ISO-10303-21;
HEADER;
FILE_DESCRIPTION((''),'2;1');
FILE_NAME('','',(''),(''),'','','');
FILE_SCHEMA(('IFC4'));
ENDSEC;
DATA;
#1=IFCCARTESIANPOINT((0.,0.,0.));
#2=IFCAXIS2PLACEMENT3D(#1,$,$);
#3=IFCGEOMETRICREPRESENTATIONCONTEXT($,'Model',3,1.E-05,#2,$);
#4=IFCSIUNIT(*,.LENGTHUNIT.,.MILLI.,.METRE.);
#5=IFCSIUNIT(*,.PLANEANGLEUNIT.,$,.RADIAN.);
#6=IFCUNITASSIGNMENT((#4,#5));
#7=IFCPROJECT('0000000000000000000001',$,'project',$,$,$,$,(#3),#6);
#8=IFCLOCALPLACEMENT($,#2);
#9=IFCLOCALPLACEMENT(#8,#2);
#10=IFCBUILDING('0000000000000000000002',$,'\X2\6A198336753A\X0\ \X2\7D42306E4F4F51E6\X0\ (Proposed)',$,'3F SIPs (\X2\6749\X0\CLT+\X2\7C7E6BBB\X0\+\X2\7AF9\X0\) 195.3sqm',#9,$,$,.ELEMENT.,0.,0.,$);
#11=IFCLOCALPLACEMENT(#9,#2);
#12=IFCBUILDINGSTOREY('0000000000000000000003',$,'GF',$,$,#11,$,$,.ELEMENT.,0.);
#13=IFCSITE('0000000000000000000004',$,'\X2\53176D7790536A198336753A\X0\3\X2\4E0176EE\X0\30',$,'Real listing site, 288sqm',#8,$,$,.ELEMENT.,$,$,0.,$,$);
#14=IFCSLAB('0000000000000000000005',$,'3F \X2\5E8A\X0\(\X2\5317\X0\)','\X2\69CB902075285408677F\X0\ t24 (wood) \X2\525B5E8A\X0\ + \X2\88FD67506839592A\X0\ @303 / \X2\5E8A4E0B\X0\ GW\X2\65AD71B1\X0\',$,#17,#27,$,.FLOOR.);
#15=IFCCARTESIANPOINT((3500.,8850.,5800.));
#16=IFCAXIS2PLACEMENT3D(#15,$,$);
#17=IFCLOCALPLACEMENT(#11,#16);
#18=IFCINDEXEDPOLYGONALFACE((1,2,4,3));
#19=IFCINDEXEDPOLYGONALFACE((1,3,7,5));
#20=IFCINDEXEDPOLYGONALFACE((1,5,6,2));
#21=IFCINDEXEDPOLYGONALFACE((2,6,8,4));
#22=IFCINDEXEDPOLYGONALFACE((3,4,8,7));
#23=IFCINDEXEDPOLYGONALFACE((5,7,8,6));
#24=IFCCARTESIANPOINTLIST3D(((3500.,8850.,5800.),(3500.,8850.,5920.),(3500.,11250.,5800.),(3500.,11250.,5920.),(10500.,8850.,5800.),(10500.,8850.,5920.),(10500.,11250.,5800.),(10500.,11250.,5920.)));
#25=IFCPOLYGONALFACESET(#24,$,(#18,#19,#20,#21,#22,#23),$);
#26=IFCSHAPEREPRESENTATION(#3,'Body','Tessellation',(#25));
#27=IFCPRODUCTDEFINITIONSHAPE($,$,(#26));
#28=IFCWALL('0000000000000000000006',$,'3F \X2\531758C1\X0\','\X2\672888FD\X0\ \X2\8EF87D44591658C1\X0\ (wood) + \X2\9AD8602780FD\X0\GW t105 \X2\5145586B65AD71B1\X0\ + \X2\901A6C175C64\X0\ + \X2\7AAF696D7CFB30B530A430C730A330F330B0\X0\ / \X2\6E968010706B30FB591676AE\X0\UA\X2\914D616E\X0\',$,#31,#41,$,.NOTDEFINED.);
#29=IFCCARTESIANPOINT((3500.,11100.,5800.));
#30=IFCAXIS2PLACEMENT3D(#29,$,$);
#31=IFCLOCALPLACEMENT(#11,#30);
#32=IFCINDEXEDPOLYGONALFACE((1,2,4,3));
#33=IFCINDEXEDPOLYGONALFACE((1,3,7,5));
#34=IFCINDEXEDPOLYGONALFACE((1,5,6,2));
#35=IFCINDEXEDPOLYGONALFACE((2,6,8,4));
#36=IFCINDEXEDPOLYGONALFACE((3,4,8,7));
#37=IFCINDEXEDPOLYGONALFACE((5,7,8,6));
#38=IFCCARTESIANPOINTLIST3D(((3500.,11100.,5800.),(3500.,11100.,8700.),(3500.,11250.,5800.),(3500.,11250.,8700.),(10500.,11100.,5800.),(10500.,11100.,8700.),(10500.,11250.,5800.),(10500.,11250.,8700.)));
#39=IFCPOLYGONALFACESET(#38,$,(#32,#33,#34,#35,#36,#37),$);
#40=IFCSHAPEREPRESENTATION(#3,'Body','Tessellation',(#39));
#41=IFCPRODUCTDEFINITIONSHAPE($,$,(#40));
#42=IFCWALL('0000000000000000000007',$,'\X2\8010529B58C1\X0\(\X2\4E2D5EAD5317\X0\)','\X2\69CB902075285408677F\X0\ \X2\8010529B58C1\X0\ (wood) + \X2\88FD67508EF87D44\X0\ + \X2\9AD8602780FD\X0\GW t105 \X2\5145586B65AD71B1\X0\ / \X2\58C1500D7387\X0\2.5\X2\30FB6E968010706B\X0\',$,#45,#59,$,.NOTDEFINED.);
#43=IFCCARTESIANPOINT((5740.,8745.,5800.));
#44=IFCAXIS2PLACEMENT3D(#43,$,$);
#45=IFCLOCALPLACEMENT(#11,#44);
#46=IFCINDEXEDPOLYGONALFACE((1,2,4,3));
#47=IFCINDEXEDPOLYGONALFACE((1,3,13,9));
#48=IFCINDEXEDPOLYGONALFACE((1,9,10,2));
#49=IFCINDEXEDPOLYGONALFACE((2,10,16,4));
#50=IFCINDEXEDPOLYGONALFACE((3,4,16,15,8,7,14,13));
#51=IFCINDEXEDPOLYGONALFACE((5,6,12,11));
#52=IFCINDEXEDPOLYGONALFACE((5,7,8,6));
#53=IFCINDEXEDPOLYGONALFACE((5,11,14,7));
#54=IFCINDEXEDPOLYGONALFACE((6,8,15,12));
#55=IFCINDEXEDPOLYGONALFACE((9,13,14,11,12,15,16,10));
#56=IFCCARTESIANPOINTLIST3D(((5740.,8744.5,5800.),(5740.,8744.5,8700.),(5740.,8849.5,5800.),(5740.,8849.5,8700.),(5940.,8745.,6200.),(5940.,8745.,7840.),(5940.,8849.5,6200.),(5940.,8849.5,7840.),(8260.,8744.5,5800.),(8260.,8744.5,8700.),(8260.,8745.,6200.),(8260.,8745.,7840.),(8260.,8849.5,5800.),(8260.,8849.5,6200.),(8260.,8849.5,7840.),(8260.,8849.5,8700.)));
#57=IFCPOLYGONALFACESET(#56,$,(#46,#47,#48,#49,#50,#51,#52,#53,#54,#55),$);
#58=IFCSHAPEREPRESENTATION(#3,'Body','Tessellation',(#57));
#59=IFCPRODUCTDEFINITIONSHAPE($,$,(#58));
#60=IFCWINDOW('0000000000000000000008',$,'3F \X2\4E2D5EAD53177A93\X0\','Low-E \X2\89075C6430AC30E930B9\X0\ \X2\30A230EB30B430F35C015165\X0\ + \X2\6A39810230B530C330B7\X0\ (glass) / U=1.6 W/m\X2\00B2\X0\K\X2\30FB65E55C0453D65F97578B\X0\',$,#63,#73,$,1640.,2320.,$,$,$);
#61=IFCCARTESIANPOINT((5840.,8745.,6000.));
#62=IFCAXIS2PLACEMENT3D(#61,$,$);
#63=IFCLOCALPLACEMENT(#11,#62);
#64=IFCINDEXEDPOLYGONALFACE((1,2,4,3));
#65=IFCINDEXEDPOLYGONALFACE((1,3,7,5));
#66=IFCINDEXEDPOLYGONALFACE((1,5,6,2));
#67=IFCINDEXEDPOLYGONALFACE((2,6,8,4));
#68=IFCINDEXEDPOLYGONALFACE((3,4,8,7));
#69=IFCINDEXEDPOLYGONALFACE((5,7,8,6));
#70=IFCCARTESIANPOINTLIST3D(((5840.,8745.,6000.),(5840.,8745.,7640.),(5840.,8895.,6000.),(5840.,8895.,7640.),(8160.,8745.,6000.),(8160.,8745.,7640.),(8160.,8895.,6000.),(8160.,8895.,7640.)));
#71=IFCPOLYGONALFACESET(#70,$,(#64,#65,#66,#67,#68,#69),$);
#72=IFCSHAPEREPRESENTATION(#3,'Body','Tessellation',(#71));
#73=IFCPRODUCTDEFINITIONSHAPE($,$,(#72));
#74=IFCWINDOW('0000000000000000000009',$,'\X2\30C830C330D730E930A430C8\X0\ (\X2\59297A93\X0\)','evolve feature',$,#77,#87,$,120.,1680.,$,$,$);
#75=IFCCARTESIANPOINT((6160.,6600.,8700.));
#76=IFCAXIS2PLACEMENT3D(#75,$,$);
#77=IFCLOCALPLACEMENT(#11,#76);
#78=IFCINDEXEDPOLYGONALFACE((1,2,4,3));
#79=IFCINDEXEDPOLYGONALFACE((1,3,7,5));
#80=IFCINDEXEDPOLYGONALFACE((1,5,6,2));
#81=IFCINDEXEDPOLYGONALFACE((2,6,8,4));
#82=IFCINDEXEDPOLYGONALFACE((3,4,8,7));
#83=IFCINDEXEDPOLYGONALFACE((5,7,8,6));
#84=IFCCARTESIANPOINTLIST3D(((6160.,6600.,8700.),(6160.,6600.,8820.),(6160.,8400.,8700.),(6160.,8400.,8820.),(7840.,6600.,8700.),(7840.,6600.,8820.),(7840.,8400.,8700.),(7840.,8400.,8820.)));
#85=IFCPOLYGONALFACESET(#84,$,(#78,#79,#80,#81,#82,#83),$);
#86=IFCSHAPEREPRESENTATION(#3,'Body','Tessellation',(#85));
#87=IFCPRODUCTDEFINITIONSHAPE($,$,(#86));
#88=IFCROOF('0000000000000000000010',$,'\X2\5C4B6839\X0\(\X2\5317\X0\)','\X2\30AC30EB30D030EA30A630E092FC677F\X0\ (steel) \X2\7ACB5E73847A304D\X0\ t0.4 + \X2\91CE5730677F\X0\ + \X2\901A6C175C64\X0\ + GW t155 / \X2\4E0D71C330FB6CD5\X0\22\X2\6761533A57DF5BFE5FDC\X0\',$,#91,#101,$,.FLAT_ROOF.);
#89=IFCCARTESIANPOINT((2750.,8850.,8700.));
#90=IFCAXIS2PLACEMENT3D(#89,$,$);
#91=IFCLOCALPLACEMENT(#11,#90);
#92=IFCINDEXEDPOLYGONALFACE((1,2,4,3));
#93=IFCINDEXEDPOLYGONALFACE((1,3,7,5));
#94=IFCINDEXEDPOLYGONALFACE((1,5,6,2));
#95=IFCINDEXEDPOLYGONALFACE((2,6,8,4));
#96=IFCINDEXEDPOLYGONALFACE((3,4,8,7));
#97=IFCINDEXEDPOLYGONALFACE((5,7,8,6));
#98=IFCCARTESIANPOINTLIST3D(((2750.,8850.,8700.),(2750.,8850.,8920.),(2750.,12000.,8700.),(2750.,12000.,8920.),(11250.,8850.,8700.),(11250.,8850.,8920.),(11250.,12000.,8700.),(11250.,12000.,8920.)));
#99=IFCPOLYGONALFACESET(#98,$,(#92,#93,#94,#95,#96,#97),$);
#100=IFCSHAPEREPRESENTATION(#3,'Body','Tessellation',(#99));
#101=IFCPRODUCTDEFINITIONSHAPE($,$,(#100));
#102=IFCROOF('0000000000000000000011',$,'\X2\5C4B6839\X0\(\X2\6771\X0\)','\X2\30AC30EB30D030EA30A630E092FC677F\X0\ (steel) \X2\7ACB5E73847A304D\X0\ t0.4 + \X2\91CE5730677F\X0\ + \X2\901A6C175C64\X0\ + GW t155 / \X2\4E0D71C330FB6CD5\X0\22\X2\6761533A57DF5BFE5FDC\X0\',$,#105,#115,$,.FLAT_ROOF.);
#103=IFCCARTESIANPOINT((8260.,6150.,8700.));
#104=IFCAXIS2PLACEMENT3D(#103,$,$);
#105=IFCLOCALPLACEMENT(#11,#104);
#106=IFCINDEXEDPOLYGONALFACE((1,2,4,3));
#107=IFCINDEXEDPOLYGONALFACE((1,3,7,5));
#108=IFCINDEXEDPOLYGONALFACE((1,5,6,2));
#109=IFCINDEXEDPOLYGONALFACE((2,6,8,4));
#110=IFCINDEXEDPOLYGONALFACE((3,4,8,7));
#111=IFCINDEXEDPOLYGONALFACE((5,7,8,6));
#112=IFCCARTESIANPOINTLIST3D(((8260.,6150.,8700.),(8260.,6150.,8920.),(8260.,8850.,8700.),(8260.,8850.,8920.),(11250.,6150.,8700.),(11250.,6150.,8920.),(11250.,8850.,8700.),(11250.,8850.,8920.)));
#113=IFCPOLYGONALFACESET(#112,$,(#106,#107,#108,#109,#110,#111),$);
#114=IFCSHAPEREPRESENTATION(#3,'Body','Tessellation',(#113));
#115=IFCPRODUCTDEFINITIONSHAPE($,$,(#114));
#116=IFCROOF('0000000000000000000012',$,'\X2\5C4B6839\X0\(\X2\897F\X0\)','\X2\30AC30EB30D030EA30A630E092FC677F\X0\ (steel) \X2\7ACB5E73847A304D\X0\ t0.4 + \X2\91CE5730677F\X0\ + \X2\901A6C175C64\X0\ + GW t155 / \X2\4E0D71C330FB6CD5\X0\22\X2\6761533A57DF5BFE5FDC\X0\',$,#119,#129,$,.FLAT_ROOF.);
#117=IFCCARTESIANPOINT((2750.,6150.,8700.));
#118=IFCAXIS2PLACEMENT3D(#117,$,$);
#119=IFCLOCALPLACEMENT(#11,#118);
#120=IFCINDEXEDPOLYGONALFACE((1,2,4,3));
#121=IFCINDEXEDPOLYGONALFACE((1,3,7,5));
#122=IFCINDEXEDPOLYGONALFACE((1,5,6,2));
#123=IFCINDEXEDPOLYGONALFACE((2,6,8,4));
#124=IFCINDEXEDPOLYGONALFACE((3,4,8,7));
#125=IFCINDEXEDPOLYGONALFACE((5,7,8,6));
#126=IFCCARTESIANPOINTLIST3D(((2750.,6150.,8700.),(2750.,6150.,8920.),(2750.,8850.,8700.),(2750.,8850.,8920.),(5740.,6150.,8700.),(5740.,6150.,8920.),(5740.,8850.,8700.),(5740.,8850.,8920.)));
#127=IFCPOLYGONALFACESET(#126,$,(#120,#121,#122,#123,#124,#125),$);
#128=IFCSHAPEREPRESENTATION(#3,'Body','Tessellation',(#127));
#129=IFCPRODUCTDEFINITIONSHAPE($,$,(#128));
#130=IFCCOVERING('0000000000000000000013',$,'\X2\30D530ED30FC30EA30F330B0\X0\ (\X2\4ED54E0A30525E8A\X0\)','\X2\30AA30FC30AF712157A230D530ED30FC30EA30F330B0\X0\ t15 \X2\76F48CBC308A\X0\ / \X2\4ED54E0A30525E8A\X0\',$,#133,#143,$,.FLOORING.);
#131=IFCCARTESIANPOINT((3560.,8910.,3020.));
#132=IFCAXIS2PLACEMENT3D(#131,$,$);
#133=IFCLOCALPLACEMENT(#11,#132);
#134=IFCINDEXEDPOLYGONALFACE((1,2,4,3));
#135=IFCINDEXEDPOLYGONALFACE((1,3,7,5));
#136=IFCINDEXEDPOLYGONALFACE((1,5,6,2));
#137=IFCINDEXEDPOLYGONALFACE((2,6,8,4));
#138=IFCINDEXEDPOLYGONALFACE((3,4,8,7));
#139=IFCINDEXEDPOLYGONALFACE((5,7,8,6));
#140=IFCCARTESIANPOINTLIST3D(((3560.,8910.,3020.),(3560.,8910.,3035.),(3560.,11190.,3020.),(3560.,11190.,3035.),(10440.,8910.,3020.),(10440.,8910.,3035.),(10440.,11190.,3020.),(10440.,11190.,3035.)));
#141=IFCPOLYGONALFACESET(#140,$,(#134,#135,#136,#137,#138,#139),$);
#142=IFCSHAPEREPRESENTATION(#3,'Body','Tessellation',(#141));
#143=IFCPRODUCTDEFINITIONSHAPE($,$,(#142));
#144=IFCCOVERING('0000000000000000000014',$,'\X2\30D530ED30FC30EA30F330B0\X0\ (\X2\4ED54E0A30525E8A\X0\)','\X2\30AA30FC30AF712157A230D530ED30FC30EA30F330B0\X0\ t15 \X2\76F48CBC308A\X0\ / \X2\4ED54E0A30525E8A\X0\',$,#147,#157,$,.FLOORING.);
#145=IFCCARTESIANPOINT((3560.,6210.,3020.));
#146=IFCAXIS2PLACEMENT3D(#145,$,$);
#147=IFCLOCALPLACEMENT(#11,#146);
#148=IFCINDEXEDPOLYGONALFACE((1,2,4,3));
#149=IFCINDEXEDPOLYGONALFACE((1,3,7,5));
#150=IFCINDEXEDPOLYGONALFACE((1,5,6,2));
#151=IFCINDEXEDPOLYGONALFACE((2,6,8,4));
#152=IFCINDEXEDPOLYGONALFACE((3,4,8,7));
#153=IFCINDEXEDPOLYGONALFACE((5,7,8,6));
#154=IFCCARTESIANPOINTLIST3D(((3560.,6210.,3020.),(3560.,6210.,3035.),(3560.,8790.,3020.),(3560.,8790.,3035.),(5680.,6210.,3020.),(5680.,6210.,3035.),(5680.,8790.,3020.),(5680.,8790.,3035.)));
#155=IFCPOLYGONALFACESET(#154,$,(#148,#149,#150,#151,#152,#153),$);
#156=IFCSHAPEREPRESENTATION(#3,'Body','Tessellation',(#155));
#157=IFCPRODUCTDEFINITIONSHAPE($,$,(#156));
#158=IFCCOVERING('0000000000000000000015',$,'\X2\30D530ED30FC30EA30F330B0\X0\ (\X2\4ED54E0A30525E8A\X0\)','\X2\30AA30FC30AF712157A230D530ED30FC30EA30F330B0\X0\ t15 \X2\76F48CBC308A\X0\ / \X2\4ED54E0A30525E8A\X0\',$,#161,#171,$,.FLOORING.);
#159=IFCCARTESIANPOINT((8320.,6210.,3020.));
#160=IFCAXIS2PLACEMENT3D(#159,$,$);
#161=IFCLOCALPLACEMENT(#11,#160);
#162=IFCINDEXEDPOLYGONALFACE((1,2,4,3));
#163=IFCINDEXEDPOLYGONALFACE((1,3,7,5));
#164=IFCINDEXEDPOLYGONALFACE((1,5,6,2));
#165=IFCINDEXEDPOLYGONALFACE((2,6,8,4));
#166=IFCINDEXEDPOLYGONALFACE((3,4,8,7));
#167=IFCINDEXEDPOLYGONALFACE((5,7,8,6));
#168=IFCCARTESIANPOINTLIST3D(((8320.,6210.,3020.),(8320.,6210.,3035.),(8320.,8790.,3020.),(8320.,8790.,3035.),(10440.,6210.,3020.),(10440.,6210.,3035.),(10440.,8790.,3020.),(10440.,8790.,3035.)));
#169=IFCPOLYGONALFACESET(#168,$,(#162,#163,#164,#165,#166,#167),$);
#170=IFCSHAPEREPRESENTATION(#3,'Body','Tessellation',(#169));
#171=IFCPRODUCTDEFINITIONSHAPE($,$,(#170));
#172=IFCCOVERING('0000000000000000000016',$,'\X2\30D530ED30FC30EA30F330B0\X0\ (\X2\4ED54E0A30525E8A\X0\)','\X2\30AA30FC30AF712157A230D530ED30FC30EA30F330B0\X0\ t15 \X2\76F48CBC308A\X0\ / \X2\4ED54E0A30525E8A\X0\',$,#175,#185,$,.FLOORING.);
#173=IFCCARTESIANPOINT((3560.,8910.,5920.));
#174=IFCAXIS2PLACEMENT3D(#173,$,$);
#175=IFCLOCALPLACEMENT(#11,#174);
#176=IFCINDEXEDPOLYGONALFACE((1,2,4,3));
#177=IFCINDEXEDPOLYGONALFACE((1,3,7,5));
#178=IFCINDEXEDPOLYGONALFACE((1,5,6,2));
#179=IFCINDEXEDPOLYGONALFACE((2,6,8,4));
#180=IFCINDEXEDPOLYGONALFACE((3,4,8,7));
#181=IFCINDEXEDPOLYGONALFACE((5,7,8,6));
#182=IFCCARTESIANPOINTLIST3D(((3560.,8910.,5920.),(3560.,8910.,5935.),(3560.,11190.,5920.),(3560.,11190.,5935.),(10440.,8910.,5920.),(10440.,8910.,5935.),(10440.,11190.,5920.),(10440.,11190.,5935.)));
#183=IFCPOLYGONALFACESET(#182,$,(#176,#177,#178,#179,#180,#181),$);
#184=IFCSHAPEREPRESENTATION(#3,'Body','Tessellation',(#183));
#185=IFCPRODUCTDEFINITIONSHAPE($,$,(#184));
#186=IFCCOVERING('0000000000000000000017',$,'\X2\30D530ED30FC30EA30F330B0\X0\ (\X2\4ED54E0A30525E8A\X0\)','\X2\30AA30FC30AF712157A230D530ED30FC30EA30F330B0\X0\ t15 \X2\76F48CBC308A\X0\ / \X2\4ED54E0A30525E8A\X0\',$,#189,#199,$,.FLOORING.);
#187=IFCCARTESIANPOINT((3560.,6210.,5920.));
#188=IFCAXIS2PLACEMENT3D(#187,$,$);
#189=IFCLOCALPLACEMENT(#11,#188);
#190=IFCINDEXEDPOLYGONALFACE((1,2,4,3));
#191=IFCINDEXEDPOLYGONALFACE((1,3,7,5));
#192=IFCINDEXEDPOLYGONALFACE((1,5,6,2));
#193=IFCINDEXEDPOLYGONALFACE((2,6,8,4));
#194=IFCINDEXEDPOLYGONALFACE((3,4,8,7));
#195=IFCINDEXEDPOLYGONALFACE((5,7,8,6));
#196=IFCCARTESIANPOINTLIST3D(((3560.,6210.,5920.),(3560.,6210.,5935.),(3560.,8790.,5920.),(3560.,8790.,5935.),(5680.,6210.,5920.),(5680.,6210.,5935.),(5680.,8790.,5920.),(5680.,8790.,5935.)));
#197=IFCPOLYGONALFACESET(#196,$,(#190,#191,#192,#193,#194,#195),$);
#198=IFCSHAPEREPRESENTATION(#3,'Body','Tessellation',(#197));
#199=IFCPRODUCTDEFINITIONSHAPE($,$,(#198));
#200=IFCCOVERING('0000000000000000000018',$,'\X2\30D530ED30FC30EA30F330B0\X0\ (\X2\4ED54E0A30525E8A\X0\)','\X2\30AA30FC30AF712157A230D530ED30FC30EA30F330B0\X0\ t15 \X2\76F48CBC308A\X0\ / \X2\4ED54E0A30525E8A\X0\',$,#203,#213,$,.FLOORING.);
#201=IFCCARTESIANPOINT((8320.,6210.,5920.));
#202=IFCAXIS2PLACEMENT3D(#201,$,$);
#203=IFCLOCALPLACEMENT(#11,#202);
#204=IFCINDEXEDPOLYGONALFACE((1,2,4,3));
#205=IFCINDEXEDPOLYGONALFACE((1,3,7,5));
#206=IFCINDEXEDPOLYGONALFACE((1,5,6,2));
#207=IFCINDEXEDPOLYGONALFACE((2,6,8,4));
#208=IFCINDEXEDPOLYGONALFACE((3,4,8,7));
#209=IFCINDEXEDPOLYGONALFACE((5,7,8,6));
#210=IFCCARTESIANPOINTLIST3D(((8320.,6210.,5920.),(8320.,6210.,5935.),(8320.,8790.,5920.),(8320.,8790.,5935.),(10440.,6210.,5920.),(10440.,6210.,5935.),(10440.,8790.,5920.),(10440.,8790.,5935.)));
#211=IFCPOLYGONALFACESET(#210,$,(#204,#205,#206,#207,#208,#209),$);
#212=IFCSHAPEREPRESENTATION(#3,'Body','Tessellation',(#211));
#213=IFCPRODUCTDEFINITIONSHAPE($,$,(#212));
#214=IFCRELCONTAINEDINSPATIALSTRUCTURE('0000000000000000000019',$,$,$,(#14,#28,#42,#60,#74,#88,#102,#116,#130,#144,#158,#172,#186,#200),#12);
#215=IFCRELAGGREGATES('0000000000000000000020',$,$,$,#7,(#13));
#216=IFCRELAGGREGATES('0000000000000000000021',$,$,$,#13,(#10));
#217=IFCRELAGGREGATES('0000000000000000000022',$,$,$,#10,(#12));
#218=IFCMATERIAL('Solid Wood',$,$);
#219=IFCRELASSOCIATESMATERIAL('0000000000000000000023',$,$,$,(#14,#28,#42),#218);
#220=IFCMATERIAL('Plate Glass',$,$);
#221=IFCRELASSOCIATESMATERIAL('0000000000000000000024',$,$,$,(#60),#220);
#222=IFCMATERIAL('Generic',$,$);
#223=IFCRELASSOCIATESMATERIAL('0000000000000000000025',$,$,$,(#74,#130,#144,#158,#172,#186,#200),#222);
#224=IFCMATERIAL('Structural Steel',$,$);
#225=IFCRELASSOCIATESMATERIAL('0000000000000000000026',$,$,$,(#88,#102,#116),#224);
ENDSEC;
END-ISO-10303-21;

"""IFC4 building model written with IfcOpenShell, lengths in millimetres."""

from ifc_helpers import new_model, si_unit, frame, frame_2d, origin, place, context, project, spatial, rectangle, extrude, material, element, fill, save


model = new_model("IFC4")

# Units and contexts
model_context = context("Model", 3, precision=1e-05, world=origin())
ifc_project = project(units=[si_unit("LENGTHUNIT", "METRE", prefix="MILLI"), si_unit("PLANEANGLEUNIT", "RADIAN")], contexts=[model_context])

# Site, building, storey
site_placement = place(None, origin())
site = spatial("IfcSite", under=ifc_project, at=site_placement, Name="北海道標茶町3丁目30", ObjectType="Real listing site, 288sqm", CompositionType="ELEMENT", RefElevation=0.0)
building_placement = place(site_placement, origin())
building = spatial("IfcBuilding", under=site, at=building_placement, Name="標茶町 終の住処 (Proposed)", ObjectType="3F SIPs (杉CLT+籾殻+竹) 195.3sqm", CompositionType="ELEMENT", ElevationOfRefHeight=0.0, ElevationOfTerrain=0.0)
storey_placement = place(building_placement, origin())
storey = spatial("IfcBuildingStorey", under=building, at=storey_placement, Name="GF", CompositionType="ELEMENT", Elevation=0.0)

# Slab
ifc_material_1 = material(Name="Solid Wood")
slab_placement = place(storey_placement, frame((3500.0, 8850.0, 5800.0)))
element("IfcSlab", 1, at=slab_placement, inside=storey, material=ifc_material_1, Name="3F 床(北)", Description="構造用合板 t24 (wood) 剛床 + 製材根太 @303 / 床下 GW断熱", PredefinedType="FLOOR", context=model_context, shape_type="SweptSolid", body=[
    extrude(rectangle(XDim=7000.0, YDim=2400.0, at=frame_2d((3500.0, 1200.0))), frame((3500.0, 8850.0, 5800.0)), (0.0, 0.0, 1.0), 120.0),
])

# Wall
wall_1_placement = place(storey_placement, frame((3500.0, 11100.0, 5800.0)))
element("IfcWall", 2, at=wall_1_placement, inside=storey, material=ifc_material_1, Name="3F 北壁", Description="木製 軸組外壁 (wood) + 高性能GW t105 充填断熱 + 通気層 + 窯業系サイディング / 準耐火・外皮UA配慮", PredefinedType="NOTDEFINED", context=model_context, shape_type="SweptSolid", body=[
    extrude(rectangle(XDim=7000.0, YDim=150.0, at=frame_2d((3500.0, 75.0))), frame((3500.0, 11100.0, 5800.0)), (0.0, 0.0, 1.0), 2900.0),
])

# Wall, opening, window
wall_2_placement = place(storey_placement, frame((5740.0, 8745.0, 5800.0)))
wall_2 = element("IfcWall", 3, at=wall_2_placement, inside=storey, material=ifc_material_1, Name="耐力壁(中庭北)", Description="構造用合板 耐力壁 (wood) + 製材軸組 + 高性能GW t105 充填断熱 / 壁倍率2.5・準耐火", PredefinedType="NOTDEFINED", context=model_context, shape_type="SweptSolid", body=[
    extrude(rectangle(XDim=2520.0, YDim=105.0, at=frame_2d((1260.0, 52.0))), frame((5740.0, 8745.0, 5800.0)), (0.0, 0.0, 1.0), 2900.0),
])
opening_placement = place(storey_placement, frame((5840.0, 8745.0, 6000.0)))
opening = element("IfcOpeningElement", 4, at=opening_placement, cuts=wall_2, PredefinedType="NOTDEFINED", context=model_context, shape_type="SweptSolid", body=[
    extrude(rectangle(XDim=2320.0, YDim=150.0, at=frame_2d((1160.0, 75.0))), frame((5840.0, 8745.0, 6000.0)), (0.0, 0.0, 1.0), 1640.0),
])
ifc_material_2 = material(Name="Plate Glass")
window_1_placement = place(storey_placement, frame((5840.0, 8745.0, 6000.0)))
window_1 = element("IfcWindow", 5, at=window_1_placement, inside=storey, material=ifc_material_2, Name="3F 中庭北窓", Description="Low-E 複層ガラス アルゴン封入 + 樹脂サッシ (glass) / U=1.6 W/m²K・日射取得型", OverallHeight=1640.0, OverallWidth=2320.0, context=model_context, shape_type="SweptSolid", body=[
    extrude(rectangle(XDim=2320.0, YDim=150.0, at=frame_2d((1160.0, 75.0))), frame((5840.0, 8745.0, 6000.0)), (0.0, 0.0, 1.0), 1640.0),
])
fill(opening, window_1)

# Window
ifc_material_3 = material(Name="Generic")
window_2_placement = place(storey_placement, frame((6160.0, 6600.0, 8700.0)))
element("IfcWindow", 6, at=window_2_placement, inside=storey, material=ifc_material_3, Name="トップライト (天窓)", Description="evolve feature", OverallHeight=120.0, OverallWidth=1680.0, context=model_context, shape_type="SweptSolid", body=[
    extrude(rectangle(XDim=1680.0, YDim=1800.0, at=frame_2d((840.0, 900.0))), frame((6160.0, 6600.0, 8700.0)), (0.0, 0.0, 1.0), 120.0),
])

# Roofs
ifc_material_4 = material(Name="Structural Steel")
roof_1_placement = place(storey_placement, frame((2750.0, 8850.0, 8700.0)))
element("IfcRoof", 7, at=roof_1_placement, inside=storey, material=ifc_material_4, Name="屋根(北)", Description="ガルバリウム鋼板 (steel) 立平葺き t0.4 + 野地板 + 通気層 + GW t155 / 不燃・法22条区域対応", PredefinedType="FLAT_ROOF", context=model_context, shape_type="SweptSolid", body=[
    extrude(rectangle(XDim=8500.0, YDim=3150.0, at=frame_2d((4250.0, 1575.0))), frame((2750.0, 8850.0, 8700.0)), (0.0, 0.0, 1.0), 220.0),
])
roof_2_placement = place(storey_placement, frame((8260.0, 6150.0, 8700.0)))
element("IfcRoof", 8, at=roof_2_placement, inside=storey, material=ifc_material_4, Name="屋根(東)", Description="ガルバリウム鋼板 (steel) 立平葺き t0.4 + 野地板 + 通気層 + GW t155 / 不燃・法22条区域対応", PredefinedType="FLAT_ROOF", context=model_context, shape_type="SweptSolid", body=[
    extrude(rectangle(XDim=2990.0, YDim=2700.0, at=frame_2d((1495.0, 1350.0))), frame((8260.0, 6150.0, 8700.0)), (0.0, 0.0, 1.0), 220.0),
])
roof_3_placement = place(storey_placement, frame((2750.0, 6150.0, 8700.0)))
element("IfcRoof", 9, at=roof_3_placement, inside=storey, material=ifc_material_4, Name="屋根(西)", Description="ガルバリウム鋼板 (steel) 立平葺き t0.4 + 野地板 + 通気層 + GW t155 / 不燃・法22条区域対応", PredefinedType="FLAT_ROOF", context=model_context, shape_type="SweptSolid", body=[
    extrude(rectangle(XDim=2990.0, YDim=2700.0, at=frame_2d((1495.0, 1350.0))), frame((2750.0, 6150.0, 8700.0)), (0.0, 0.0, 1.0), 220.0),
])

# Coverings
covering_1_placement = place(storey_placement, frame((3560.0, 8910.0, 3020.0)))
element("IfcCovering", 10, at=covering_1_placement, inside=storey, material=ifc_material_3, Name="フローリング (仕上げ床)", Description="オーク無垢フローリング t15 直貼り / 仕上げ床", PredefinedType="FLOORING", context=model_context, shape_type="SweptSolid", body=[
    extrude(rectangle(XDim=6880.0, YDim=2280.0, at=frame_2d((3440.0, 1140.0))), frame((3560.0, 8910.0, 3020.0)), (0.0, 0.0, 1.0), 15.0),
])
covering_2_placement = place(storey_placement, frame((3560.0, 6210.0, 3020.0)))
element("IfcCovering", 11, at=covering_2_placement, inside=storey, material=ifc_material_3, Name="フローリング (仕上げ床)", Description="オーク無垢フローリング t15 直貼り / 仕上げ床", PredefinedType="FLOORING", context=model_context, shape_type="SweptSolid", body=[
    extrude(rectangle(XDim=2120.0, YDim=2580.0, at=frame_2d((1060.0, 1290.0))), frame((3560.0, 6210.0, 3020.0)), (0.0, 0.0, 1.0), 15.0),
])
covering_3_placement = place(storey_placement, frame((8320.0, 6210.0, 3020.0)))
element("IfcCovering", 12, at=covering_3_placement, inside=storey, material=ifc_material_3, Name="フローリング (仕上げ床)", Description="オーク無垢フローリング t15 直貼り / 仕上げ床", PredefinedType="FLOORING", context=model_context, shape_type="SweptSolid", body=[
    extrude(rectangle(XDim=2120.0, YDim=2580.0, at=frame_2d((1060.0, 1290.0))), frame((8320.0, 6210.0, 3020.0)), (0.0, 0.0, 1.0), 15.0),
])
covering_4_placement = place(storey_placement, frame((3560.0, 8910.0, 5920.0)))
element("IfcCovering", 13, at=covering_4_placement, inside=storey, material=ifc_material_3, Name="フローリング (仕上げ床)", Description="オーク無垢フローリング t15 直貼り / 仕上げ床", PredefinedType="FLOORING", context=model_context, shape_type="SweptSolid", body=[
    extrude(rectangle(XDim=6880.0, YDim=2280.0, at=frame_2d((3440.0, 1140.0))), frame((3560.0, 8910.0, 5920.0)), (0.0, 0.0, 1.0), 15.0),
])
covering_5_placement = place(storey_placement, frame((3560.0, 6210.0, 5920.0)))
element("IfcCovering", 14, at=covering_5_placement, inside=storey, material=ifc_material_3, Name="フローリング (仕上げ床)", Description="オーク無垢フローリング t15 直貼り / 仕上げ床", PredefinedType="FLOORING", context=model_context, shape_type="SweptSolid", body=[
    extrude(rectangle(XDim=2120.0, YDim=2580.0, at=frame_2d((1060.0, 1290.0))), frame((3560.0, 6210.0, 5920.0)), (0.0, 0.0, 1.0), 15.0),
])
covering_6_placement = place(storey_placement, frame((8320.0, 6210.0, 5920.0)))
element("IfcCovering", 15, at=covering_6_placement, inside=storey, material=ifc_material_3, Name="フローリング (仕上げ床)", Description="オーク無垢フローリング t15 直貼り / 仕上げ床", PredefinedType="FLOORING", context=model_context, shape_type="SweptSolid", body=[
    extrude(rectangle(XDim=2120.0, YDim=2580.0, at=frame_2d((1060.0, 1290.0))), frame((8320.0, 6210.0, 5920.0)), (0.0, 0.0, 1.0), 15.0),
])

save(model, "model.ifc")
